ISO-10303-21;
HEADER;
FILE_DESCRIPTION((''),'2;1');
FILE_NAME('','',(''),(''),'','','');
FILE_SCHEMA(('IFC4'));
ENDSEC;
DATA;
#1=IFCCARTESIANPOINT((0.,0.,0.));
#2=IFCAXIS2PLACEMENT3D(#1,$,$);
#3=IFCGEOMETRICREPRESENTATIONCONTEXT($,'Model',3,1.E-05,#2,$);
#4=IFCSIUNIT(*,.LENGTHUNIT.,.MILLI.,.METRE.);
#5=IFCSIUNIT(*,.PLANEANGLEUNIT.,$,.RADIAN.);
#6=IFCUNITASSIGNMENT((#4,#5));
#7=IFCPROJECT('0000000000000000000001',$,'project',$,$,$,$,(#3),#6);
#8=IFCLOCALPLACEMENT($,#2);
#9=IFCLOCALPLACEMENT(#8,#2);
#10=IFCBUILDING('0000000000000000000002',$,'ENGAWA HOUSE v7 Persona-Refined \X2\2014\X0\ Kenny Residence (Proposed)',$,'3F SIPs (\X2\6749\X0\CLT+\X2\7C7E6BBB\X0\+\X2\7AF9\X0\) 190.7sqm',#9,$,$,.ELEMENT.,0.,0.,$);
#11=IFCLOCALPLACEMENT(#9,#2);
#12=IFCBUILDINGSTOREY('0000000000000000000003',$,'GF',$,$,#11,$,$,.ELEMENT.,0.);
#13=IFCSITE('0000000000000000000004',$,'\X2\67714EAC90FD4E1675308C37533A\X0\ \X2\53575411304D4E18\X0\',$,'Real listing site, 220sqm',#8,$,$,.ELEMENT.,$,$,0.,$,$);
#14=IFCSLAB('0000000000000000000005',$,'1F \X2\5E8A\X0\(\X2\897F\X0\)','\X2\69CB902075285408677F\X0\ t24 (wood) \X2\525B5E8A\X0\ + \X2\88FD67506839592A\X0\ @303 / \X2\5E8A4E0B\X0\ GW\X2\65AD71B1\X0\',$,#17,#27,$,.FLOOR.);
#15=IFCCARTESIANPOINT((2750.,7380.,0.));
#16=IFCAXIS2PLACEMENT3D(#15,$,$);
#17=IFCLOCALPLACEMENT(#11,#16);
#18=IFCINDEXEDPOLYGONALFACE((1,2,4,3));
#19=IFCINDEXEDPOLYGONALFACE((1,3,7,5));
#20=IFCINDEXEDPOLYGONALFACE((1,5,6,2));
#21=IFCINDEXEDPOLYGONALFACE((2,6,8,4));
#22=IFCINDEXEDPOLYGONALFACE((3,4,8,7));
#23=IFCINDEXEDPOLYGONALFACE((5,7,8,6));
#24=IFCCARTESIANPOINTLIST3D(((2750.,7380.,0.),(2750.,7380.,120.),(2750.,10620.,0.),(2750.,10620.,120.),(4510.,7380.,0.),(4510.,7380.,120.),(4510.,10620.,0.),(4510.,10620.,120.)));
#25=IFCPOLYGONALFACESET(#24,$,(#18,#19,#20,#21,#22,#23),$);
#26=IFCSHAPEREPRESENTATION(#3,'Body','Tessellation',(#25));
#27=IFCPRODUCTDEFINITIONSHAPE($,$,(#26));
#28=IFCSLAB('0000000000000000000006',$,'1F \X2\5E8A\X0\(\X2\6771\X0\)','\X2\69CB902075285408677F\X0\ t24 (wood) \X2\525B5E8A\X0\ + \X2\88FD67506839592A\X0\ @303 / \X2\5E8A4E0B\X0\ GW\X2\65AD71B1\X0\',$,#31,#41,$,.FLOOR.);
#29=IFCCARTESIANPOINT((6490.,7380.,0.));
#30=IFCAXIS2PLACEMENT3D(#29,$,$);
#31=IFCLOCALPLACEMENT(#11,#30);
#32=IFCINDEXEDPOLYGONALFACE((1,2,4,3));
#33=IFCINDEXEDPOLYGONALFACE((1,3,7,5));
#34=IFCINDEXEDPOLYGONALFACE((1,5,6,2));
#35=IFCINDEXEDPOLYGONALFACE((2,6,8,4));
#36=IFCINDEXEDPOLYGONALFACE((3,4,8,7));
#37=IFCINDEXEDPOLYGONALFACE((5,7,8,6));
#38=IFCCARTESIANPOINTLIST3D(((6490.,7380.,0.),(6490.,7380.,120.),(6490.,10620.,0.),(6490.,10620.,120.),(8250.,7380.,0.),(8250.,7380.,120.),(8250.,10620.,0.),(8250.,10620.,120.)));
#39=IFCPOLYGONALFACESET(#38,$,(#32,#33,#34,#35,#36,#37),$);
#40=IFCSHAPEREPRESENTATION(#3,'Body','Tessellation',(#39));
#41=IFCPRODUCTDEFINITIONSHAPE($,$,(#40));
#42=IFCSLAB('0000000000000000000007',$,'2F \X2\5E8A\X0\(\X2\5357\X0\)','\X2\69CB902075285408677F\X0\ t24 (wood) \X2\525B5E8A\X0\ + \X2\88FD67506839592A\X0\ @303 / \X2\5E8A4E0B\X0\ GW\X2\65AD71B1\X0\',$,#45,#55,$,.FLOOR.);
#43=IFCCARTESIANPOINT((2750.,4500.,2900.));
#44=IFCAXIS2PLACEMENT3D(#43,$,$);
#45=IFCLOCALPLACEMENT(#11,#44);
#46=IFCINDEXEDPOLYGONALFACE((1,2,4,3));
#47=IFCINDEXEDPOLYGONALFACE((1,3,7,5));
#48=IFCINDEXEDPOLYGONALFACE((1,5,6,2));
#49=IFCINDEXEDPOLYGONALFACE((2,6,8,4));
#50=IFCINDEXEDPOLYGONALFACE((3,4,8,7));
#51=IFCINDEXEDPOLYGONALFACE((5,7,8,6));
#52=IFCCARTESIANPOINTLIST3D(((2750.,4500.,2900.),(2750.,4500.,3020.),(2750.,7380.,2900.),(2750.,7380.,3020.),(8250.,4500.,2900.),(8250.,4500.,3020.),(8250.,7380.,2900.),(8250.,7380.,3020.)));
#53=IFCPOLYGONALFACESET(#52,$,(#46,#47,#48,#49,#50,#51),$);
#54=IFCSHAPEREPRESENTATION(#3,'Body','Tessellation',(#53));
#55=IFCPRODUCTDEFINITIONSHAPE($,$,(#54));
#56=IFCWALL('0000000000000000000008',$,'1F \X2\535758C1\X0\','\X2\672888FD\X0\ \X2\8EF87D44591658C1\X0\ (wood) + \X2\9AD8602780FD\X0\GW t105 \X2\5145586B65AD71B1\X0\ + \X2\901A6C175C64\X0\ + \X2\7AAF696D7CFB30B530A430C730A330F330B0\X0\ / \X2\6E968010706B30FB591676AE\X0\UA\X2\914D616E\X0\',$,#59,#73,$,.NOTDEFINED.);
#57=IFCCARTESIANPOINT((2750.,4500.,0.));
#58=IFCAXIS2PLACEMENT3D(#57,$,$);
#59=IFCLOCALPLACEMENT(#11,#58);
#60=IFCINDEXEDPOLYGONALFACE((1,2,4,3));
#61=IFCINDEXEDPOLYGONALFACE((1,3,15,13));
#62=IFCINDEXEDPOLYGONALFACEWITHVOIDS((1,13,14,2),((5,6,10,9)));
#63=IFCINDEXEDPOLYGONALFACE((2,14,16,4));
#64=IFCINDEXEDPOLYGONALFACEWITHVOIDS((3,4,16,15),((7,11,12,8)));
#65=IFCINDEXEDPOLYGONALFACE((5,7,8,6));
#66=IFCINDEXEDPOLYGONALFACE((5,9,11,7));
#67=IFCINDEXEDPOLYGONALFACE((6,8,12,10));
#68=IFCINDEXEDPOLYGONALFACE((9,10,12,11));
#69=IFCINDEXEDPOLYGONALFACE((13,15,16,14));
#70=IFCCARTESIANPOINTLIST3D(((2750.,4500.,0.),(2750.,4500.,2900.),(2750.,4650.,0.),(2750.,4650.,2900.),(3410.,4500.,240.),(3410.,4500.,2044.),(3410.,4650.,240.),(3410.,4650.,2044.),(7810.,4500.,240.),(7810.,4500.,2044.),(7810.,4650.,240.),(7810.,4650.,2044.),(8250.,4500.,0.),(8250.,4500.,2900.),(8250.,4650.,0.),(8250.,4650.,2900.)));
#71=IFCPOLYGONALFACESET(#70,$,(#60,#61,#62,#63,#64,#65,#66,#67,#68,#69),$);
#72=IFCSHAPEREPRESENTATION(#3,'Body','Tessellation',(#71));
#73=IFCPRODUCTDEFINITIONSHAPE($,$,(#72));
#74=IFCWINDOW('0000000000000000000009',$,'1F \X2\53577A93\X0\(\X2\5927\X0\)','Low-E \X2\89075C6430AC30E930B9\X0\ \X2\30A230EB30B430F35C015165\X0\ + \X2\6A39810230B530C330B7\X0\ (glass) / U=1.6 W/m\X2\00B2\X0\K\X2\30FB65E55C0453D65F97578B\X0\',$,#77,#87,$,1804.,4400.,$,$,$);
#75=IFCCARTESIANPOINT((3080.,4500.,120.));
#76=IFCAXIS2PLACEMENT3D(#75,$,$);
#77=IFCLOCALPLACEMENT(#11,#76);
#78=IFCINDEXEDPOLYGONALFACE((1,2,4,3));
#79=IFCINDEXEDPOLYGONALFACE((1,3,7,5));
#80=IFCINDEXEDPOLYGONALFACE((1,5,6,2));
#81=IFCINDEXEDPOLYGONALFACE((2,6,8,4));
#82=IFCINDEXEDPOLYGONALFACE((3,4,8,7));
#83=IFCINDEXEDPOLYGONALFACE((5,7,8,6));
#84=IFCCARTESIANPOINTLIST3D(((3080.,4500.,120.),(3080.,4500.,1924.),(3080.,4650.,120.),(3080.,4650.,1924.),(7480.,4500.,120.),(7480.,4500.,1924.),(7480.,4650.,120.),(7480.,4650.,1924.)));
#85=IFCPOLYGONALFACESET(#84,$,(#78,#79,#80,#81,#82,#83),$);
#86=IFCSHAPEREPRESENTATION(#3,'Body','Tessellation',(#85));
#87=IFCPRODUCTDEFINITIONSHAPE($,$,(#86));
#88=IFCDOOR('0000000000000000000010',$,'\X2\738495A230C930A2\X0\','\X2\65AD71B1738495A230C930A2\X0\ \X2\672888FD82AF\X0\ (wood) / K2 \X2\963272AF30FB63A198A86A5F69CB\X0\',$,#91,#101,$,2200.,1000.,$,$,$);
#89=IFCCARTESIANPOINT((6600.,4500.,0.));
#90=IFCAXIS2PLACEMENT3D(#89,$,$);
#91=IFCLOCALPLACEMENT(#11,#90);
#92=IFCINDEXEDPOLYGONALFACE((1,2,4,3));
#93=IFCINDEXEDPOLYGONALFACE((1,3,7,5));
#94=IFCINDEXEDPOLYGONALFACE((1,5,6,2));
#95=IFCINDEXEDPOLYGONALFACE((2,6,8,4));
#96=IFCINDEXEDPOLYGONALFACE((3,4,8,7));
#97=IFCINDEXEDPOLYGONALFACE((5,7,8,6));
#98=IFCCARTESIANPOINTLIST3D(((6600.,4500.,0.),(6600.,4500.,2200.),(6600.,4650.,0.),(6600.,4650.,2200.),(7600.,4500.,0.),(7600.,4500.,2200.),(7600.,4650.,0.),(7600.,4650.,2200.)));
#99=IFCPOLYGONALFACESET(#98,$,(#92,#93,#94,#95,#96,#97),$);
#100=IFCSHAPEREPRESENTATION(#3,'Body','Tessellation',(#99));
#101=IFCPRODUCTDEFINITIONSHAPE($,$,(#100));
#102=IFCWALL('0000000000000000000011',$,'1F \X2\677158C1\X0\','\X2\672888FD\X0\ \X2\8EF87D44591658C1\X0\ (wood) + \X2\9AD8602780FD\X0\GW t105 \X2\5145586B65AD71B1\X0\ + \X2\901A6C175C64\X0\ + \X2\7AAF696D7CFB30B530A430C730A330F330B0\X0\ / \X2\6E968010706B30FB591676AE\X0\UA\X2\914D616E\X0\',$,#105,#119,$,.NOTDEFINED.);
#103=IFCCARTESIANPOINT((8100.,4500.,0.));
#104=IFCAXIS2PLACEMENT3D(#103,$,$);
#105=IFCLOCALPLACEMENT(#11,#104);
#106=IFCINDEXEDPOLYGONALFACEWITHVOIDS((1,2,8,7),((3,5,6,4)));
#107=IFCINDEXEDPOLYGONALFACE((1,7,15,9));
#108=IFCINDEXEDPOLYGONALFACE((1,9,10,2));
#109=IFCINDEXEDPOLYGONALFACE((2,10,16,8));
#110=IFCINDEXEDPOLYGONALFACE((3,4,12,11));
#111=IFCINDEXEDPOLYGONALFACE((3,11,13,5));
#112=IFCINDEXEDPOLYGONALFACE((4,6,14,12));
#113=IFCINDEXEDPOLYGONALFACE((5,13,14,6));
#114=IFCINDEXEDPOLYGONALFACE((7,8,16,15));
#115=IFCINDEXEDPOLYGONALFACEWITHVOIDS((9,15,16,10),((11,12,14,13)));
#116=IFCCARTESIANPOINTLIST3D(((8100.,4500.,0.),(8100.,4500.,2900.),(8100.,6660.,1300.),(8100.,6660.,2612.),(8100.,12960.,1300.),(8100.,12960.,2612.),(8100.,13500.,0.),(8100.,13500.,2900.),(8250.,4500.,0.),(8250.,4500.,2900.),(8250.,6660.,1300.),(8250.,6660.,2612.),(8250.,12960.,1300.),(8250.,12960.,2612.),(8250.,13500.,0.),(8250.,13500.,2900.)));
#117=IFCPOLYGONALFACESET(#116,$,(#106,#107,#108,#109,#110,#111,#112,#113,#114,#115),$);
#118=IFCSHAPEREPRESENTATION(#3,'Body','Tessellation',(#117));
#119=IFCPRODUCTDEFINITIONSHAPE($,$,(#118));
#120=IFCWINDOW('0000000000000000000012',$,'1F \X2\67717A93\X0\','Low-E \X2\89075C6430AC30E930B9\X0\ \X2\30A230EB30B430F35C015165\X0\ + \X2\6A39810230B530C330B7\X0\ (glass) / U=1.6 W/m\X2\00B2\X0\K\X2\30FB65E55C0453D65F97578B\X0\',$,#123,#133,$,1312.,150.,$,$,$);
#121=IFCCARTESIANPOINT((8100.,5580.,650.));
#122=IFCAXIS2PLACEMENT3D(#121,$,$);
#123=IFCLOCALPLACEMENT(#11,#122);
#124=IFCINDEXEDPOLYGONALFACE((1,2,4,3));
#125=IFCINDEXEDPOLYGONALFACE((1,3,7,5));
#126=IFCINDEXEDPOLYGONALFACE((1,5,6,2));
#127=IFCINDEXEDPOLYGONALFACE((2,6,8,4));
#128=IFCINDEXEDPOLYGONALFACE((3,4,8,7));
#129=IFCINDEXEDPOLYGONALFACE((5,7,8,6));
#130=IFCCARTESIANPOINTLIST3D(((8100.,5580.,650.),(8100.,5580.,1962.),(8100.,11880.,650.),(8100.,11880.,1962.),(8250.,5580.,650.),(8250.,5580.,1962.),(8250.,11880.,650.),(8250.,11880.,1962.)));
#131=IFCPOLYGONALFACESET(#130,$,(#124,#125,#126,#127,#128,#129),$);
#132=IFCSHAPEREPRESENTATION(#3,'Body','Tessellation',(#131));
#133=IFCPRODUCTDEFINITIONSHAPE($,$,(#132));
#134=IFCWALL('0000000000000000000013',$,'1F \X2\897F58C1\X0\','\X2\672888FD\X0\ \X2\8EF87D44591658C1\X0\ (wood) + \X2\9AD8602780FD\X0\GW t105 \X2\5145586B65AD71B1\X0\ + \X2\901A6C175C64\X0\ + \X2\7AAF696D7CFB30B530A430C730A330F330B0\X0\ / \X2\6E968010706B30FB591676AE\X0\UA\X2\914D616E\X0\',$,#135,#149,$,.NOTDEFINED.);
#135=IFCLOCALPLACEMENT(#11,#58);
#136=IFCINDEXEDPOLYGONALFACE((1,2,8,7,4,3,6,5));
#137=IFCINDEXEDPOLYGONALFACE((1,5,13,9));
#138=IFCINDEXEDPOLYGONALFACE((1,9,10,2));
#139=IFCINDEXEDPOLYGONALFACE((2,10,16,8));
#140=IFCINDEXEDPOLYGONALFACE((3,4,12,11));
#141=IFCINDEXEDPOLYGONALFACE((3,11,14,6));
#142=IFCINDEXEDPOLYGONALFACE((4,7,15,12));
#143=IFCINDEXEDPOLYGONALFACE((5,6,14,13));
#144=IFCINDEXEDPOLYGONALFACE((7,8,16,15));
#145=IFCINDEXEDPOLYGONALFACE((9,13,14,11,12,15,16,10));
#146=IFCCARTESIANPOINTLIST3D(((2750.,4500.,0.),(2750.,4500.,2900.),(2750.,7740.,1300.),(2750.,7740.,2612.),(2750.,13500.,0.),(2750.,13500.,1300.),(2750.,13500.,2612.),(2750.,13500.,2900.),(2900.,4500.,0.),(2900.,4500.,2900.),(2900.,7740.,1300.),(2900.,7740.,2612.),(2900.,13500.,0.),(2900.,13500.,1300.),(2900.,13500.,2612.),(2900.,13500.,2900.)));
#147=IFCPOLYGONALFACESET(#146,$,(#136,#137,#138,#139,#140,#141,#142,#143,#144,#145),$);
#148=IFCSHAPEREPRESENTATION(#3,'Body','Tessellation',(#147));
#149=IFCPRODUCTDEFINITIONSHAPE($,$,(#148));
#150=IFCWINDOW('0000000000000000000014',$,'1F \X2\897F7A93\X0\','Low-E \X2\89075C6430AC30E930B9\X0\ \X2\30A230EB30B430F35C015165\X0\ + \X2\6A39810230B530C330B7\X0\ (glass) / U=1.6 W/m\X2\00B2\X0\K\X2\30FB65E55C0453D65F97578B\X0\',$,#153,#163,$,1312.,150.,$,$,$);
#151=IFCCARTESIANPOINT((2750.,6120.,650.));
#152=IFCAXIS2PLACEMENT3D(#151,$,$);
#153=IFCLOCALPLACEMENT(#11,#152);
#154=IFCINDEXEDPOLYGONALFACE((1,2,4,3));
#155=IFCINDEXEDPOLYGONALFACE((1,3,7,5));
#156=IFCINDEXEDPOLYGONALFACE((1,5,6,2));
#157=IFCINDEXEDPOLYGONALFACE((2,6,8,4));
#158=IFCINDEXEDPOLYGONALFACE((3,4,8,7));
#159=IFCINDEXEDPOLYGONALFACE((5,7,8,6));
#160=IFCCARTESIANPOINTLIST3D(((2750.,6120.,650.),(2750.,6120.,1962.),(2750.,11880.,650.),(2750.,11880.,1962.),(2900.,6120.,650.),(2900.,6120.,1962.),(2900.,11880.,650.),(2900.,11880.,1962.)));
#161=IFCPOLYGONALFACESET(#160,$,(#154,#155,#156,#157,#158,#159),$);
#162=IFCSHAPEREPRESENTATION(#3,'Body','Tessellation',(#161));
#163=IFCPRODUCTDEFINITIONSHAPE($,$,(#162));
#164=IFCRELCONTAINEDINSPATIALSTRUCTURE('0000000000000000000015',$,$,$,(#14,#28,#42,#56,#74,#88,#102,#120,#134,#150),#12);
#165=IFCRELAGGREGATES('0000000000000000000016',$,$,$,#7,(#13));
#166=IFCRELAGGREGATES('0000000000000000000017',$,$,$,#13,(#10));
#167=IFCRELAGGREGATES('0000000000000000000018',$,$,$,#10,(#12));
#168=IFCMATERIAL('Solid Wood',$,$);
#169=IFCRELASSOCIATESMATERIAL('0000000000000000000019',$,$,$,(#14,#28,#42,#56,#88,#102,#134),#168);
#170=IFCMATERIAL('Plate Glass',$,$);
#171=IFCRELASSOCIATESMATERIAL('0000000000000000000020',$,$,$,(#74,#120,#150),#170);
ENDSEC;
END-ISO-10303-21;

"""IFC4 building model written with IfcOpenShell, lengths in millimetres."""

from ifc_helpers import new_model, si_unit, frame, frame_2d, origin, place, context, project, spatial, rectangle, extrude, material, element, fill, save


model = new_model("IFC4")

# Units and contexts
model_context = context("Model", 3, precision=1e-05, world=origin())
ifc_project = project(units=[si_unit("LENGTHUNIT", "METRE", prefix="MILLI"), si_unit("PLANEANGLEUNIT", "RADIAN")], contexts=[model_context])

# Site, building, storey
site_placement = place(None, origin())
site = spatial("IfcSite", under=ifc_project, at=site_placement, Name="東京都世田谷区 南向き丘", ObjectType="Real listing site, 220sqm", CompositionType="ELEMENT", RefElevation=0.0)
building_placement = place(site_placement, origin())
building = spatial("IfcBuilding", under=site, at=building_placement, Name="ENGAWA HOUSE v7 Persona-Refined — Kenny Residence (Proposed)", ObjectType="3F SIPs (杉CLT+籾殻+竹) 190.7sqm", CompositionType="ELEMENT", ElevationOfRefHeight=0.0, ElevationOfTerrain=0.0)
storey_placement = place(building_placement, origin())
storey = spatial("IfcBuildingStorey", under=building, at=storey_placement, Name="GF", CompositionType="ELEMENT", Elevation=0.0)

# Slabs
ifc_material_1 = material(Name="Solid Wood")
slab_1_placement = place(storey_placement, frame((2750.0, 7380.0, 0.0)))
element("IfcSlab", 1, at=slab_1_placement, inside=storey, material=ifc_material_1, Name="1F 床(西)", Description="構造用合板 t24 (wood) 剛床 + 製材根太 @303 / 床下 GW断熱", PredefinedType="FLOOR", context=model_context, shape_type="SweptSolid", body=[
    extrude(rectangle(XDim=1760.0, YDim=3240.0, at=frame_2d((880.0, 1620.0))), frame((2750.0, 7380.0, 0.0)), (0.0, 0.0, 1.0), 120.0),
])
slab_2_placement = place(storey_placement, frame((6490.0, 7380.0, 0.0)))
element("IfcSlab", 2, at=slab_2_placement, inside=storey, material=ifc_material_1, Name="1F 床(東)", Description="構造用合板 t24 (wood) 剛床 + 製材根太 @303 / 床下 GW断熱", PredefinedType="FLOOR", context=model_context, shape_type="SweptSolid", body=[
    extrude(rectangle(XDim=1760.0, YDim=3240.0, at=frame_2d((880.0, 1620.0))), frame((6490.0, 7380.0, 0.0)), (0.0, 0.0, 1.0), 120.0),
])
slab_3_placement = place(storey_placement, frame((2750.0, 4500.0, 2900.0)))
element("IfcSlab", 3, at=slab_3_placement, inside=storey, material=ifc_material_1, Name="2F 床(南)", Description="構造用合板 t24 (wood) 剛床 + 製材根太 @303 / 床下 GW断熱", PredefinedType="FLOOR", context=model_context, shape_type="SweptSolid", body=[
    extrude(rectangle(XDim=5500.0, YDim=2880.0, at=frame_2d((2750.0, 1440.0))), frame((2750.0, 4500.0, 2900.0)), (0.0, 0.0, 1.0), 120.0),
])

# Wall, openings, window, door
wall_1_placement = place(storey_placement, frame((2750.0, 4500.0, 0.0)))
wall_1 = element("IfcWall", 4, at=wall_1_placement, inside=storey, material=ifc_material_1, Name="1F 南壁", Description="木製 軸組外壁 (wood) + 高性能GW t105 充填断熱 + 通気層 + 窯業系サイディング / 準耐火・外皮UA配慮", PredefinedType="NOTDEFINED", context=model_context, shape_type="SweptSolid", body=[
    extrude(rectangle(XDim=5500.0, YDim=150.0, at=frame_2d((2750.0, 75.0))), frame((2750.0, 4500.0, 0.0)), (0.0, 0.0, 1.0), 2900.0),
])
opening_1_placement = place(storey_placement, frame((3080.0, 4500.0, 120.0)))
opening_1 = element("IfcOpeningElement", 5, at=opening_1_placement, cuts=wall_1, PredefinedType="NOTDEFINED", context=model_context, shape_type="SweptSolid", body=[
    extrude(rectangle(XDim=4400.0, YDim=150.0, at=frame_2d((2200.0, 75.0))), frame((3080.0, 4500.0, 120.0)), (0.0, 0.0, 1.0), 1804.0),
])
opening_2_placement = place(storey_placement, frame((6600.0, 4500.0, 0.0)))
opening_2 = element("IfcOpeningElement", 6, at=opening_2_placement, cuts=wall_1, PredefinedType="NOTDEFINED", context=model_context, shape_type="SweptSolid", body=[
    extrude(rectangle(XDim=1000.0, YDim=150.0, at=frame_2d((500.0, 75.0))), frame((6600.0, 4500.0, 0.0)), (0.0, 0.0, 1.0), 2200.0),
])
ifc_material_2 = material(Name="Plate Glass")
window_1_placement = place(storey_placement, frame((3080.0, 4500.0, 120.0)))
window_1 = element("IfcWindow", 7, at=window_1_placement, inside=storey, material=ifc_material_2, Name="1F 南窓(大)", Description="Low-E 複層ガラス アルゴン封入 + 樹脂サッシ (glass) / U=1.6 W/m²K・日射取得型", OverallHeight=1804.0, OverallWidth=4400.0, context=model_context, shape_type="SweptSolid", body=[
    extrude(rectangle(XDim=4400.0, YDim=150.0, at=frame_2d((2200.0, 75.0))), frame((3080.0, 4500.0, 120.0)), (0.0, 0.0, 1.0), 1804.0),
])
fill(opening_1, window_1)
door_placement = place(storey_placement, frame((6600.0, 4500.0, 0.0)))
door = element("IfcDoor", 8, at=door_placement, inside=storey, material=ifc_material_1, Name="玄関ドア", Description="断熱玄関ドア 木製芯 (wood) / K2 防犯・採風機構", OverallHeight=2200.0, OverallWidth=1000.0, context=model_context, shape_type="SweptSolid", body=[
    extrude(rectangle(XDim=1000.0, YDim=150.0, at=frame_2d((500.0, 75.0))), frame((6600.0, 4500.0, 0.0)), (0.0, 0.0, 1.0), 2200.0),
])
fill(opening_2, door)

# Walls, openings, windows
wall_2_placement = place(storey_placement, frame((8100.0, 4500.0, 0.0)))
wall_2 = element("IfcWall", 9, at=wall_2_placement, inside=storey, material=ifc_material_1, Name="1F 東壁", Description="木製 軸組外壁 (wood) + 高性能GW t105 充填断熱 + 通気層 + 窯業系サイディング / 準耐火・外皮UA配慮", PredefinedType="NOTDEFINED", context=model_context, shape_type="SweptSolid", body=[
    extrude(rectangle(XDim=150.0, YDim=9000.0, at=frame_2d((75.0, 4500.0))), frame((8100.0, 4500.0, 0.0)), (0.0, 0.0, 1.0), 2900.0),
])
opening_3_placement = place(storey_placement, frame((8100.0, 5580.0, 650.0)))
opening_3 = element("IfcOpeningElement", 10, at=opening_3_placement, cuts=wall_2, PredefinedType="NOTDEFINED", context=model_context, shape_type="SweptSolid", body=[
    extrude(rectangle(XDim=150.0, YDim=6300.0, at=frame_2d((75.0, 3150.0))), frame((8100.0, 5580.0, 650.0)), (0.0, 0.0, 1.0), 1312.0),
])
window_2_placement = place(storey_placement, frame((8100.0, 5580.0, 650.0)))
window_2 = element("IfcWindow", 11, at=window_2_placement, inside=storey, material=ifc_material_2, Name="1F 東窓", Description="Low-E 複層ガラス アルゴン封入 + 樹脂サッシ (glass) / U=1.6 W/m²K・日射取得型", OverallHeight=1312.0, OverallWidth=150.0, context=model_context, shape_type="SweptSolid", body=[
    extrude(rectangle(XDim=150.0, YDim=6300.0, at=frame_2d((75.0, 3150.0))), frame((8100.0, 5580.0, 650.0)), (0.0, 0.0, 1.0), 1312.0),
])
fill(opening_3, window_2)
wall_3_placement = place(storey_placement, frame((2750.0, 4500.0, 0.0)))
wall_3 = element("IfcWall", 12, at=wall_3_placement, inside=storey, material=ifc_material_1, Name="1F 西壁", Description="木製 軸組外壁 (wood) + 高性能GW t105 充填断熱 + 通気層 + 窯業系サイディング / 準耐火・外皮UA配慮", PredefinedType="NOTDEFINED", context=model_context, shape_type="SweptSolid", body=[
    extrude(rectangle(XDim=150.0, YDim=9000.0, at=frame_2d((75.0, 4500.0))), frame((2750.0, 4500.0, 0.0)), (0.0, 0.0, 1.0), 2900.0),
])
opening_4_placement = place(storey_placement, frame((2750.0, 6120.0, 650.0)))
opening_4 = element("IfcOpeningElement", 13, at=opening_4_placement, cuts=wall_3, PredefinedType="NOTDEFINED", context=model_context, shape_type="SweptSolid", body=[
    extrude(rectangle(XDim=150.0, YDim=5760.0, at=frame_2d((75.0, 2880.0))), frame((2750.0, 6120.0, 650.0)), (0.0, 0.0, 1.0), 1312.0),
])
window_3_placement = place(storey_placement, frame((2750.0, 6120.0, 650.0)))
window_3 = element("IfcWindow", 14, at=window_3_placement, inside=storey, material=ifc_material_2, Name="1F 西窓", Description="Low-E 複層ガラス アルゴン封入 + 樹脂サッシ (glass) / U=1.6 W/m²K・日射取得型", OverallHeight=1312.0, OverallWidth=150.0, context=model_context, shape_type="SweptSolid", body=[
    extrude(rectangle(XDim=150.0, YDim=5760.0, at=frame_2d((75.0, 2880.0))), frame((2750.0, 6120.0, 650.0)), (0.0, 0.0, 1.0), 1312.0),
])
fill(opening_4, window_3)

save(model, "model.ifc")
